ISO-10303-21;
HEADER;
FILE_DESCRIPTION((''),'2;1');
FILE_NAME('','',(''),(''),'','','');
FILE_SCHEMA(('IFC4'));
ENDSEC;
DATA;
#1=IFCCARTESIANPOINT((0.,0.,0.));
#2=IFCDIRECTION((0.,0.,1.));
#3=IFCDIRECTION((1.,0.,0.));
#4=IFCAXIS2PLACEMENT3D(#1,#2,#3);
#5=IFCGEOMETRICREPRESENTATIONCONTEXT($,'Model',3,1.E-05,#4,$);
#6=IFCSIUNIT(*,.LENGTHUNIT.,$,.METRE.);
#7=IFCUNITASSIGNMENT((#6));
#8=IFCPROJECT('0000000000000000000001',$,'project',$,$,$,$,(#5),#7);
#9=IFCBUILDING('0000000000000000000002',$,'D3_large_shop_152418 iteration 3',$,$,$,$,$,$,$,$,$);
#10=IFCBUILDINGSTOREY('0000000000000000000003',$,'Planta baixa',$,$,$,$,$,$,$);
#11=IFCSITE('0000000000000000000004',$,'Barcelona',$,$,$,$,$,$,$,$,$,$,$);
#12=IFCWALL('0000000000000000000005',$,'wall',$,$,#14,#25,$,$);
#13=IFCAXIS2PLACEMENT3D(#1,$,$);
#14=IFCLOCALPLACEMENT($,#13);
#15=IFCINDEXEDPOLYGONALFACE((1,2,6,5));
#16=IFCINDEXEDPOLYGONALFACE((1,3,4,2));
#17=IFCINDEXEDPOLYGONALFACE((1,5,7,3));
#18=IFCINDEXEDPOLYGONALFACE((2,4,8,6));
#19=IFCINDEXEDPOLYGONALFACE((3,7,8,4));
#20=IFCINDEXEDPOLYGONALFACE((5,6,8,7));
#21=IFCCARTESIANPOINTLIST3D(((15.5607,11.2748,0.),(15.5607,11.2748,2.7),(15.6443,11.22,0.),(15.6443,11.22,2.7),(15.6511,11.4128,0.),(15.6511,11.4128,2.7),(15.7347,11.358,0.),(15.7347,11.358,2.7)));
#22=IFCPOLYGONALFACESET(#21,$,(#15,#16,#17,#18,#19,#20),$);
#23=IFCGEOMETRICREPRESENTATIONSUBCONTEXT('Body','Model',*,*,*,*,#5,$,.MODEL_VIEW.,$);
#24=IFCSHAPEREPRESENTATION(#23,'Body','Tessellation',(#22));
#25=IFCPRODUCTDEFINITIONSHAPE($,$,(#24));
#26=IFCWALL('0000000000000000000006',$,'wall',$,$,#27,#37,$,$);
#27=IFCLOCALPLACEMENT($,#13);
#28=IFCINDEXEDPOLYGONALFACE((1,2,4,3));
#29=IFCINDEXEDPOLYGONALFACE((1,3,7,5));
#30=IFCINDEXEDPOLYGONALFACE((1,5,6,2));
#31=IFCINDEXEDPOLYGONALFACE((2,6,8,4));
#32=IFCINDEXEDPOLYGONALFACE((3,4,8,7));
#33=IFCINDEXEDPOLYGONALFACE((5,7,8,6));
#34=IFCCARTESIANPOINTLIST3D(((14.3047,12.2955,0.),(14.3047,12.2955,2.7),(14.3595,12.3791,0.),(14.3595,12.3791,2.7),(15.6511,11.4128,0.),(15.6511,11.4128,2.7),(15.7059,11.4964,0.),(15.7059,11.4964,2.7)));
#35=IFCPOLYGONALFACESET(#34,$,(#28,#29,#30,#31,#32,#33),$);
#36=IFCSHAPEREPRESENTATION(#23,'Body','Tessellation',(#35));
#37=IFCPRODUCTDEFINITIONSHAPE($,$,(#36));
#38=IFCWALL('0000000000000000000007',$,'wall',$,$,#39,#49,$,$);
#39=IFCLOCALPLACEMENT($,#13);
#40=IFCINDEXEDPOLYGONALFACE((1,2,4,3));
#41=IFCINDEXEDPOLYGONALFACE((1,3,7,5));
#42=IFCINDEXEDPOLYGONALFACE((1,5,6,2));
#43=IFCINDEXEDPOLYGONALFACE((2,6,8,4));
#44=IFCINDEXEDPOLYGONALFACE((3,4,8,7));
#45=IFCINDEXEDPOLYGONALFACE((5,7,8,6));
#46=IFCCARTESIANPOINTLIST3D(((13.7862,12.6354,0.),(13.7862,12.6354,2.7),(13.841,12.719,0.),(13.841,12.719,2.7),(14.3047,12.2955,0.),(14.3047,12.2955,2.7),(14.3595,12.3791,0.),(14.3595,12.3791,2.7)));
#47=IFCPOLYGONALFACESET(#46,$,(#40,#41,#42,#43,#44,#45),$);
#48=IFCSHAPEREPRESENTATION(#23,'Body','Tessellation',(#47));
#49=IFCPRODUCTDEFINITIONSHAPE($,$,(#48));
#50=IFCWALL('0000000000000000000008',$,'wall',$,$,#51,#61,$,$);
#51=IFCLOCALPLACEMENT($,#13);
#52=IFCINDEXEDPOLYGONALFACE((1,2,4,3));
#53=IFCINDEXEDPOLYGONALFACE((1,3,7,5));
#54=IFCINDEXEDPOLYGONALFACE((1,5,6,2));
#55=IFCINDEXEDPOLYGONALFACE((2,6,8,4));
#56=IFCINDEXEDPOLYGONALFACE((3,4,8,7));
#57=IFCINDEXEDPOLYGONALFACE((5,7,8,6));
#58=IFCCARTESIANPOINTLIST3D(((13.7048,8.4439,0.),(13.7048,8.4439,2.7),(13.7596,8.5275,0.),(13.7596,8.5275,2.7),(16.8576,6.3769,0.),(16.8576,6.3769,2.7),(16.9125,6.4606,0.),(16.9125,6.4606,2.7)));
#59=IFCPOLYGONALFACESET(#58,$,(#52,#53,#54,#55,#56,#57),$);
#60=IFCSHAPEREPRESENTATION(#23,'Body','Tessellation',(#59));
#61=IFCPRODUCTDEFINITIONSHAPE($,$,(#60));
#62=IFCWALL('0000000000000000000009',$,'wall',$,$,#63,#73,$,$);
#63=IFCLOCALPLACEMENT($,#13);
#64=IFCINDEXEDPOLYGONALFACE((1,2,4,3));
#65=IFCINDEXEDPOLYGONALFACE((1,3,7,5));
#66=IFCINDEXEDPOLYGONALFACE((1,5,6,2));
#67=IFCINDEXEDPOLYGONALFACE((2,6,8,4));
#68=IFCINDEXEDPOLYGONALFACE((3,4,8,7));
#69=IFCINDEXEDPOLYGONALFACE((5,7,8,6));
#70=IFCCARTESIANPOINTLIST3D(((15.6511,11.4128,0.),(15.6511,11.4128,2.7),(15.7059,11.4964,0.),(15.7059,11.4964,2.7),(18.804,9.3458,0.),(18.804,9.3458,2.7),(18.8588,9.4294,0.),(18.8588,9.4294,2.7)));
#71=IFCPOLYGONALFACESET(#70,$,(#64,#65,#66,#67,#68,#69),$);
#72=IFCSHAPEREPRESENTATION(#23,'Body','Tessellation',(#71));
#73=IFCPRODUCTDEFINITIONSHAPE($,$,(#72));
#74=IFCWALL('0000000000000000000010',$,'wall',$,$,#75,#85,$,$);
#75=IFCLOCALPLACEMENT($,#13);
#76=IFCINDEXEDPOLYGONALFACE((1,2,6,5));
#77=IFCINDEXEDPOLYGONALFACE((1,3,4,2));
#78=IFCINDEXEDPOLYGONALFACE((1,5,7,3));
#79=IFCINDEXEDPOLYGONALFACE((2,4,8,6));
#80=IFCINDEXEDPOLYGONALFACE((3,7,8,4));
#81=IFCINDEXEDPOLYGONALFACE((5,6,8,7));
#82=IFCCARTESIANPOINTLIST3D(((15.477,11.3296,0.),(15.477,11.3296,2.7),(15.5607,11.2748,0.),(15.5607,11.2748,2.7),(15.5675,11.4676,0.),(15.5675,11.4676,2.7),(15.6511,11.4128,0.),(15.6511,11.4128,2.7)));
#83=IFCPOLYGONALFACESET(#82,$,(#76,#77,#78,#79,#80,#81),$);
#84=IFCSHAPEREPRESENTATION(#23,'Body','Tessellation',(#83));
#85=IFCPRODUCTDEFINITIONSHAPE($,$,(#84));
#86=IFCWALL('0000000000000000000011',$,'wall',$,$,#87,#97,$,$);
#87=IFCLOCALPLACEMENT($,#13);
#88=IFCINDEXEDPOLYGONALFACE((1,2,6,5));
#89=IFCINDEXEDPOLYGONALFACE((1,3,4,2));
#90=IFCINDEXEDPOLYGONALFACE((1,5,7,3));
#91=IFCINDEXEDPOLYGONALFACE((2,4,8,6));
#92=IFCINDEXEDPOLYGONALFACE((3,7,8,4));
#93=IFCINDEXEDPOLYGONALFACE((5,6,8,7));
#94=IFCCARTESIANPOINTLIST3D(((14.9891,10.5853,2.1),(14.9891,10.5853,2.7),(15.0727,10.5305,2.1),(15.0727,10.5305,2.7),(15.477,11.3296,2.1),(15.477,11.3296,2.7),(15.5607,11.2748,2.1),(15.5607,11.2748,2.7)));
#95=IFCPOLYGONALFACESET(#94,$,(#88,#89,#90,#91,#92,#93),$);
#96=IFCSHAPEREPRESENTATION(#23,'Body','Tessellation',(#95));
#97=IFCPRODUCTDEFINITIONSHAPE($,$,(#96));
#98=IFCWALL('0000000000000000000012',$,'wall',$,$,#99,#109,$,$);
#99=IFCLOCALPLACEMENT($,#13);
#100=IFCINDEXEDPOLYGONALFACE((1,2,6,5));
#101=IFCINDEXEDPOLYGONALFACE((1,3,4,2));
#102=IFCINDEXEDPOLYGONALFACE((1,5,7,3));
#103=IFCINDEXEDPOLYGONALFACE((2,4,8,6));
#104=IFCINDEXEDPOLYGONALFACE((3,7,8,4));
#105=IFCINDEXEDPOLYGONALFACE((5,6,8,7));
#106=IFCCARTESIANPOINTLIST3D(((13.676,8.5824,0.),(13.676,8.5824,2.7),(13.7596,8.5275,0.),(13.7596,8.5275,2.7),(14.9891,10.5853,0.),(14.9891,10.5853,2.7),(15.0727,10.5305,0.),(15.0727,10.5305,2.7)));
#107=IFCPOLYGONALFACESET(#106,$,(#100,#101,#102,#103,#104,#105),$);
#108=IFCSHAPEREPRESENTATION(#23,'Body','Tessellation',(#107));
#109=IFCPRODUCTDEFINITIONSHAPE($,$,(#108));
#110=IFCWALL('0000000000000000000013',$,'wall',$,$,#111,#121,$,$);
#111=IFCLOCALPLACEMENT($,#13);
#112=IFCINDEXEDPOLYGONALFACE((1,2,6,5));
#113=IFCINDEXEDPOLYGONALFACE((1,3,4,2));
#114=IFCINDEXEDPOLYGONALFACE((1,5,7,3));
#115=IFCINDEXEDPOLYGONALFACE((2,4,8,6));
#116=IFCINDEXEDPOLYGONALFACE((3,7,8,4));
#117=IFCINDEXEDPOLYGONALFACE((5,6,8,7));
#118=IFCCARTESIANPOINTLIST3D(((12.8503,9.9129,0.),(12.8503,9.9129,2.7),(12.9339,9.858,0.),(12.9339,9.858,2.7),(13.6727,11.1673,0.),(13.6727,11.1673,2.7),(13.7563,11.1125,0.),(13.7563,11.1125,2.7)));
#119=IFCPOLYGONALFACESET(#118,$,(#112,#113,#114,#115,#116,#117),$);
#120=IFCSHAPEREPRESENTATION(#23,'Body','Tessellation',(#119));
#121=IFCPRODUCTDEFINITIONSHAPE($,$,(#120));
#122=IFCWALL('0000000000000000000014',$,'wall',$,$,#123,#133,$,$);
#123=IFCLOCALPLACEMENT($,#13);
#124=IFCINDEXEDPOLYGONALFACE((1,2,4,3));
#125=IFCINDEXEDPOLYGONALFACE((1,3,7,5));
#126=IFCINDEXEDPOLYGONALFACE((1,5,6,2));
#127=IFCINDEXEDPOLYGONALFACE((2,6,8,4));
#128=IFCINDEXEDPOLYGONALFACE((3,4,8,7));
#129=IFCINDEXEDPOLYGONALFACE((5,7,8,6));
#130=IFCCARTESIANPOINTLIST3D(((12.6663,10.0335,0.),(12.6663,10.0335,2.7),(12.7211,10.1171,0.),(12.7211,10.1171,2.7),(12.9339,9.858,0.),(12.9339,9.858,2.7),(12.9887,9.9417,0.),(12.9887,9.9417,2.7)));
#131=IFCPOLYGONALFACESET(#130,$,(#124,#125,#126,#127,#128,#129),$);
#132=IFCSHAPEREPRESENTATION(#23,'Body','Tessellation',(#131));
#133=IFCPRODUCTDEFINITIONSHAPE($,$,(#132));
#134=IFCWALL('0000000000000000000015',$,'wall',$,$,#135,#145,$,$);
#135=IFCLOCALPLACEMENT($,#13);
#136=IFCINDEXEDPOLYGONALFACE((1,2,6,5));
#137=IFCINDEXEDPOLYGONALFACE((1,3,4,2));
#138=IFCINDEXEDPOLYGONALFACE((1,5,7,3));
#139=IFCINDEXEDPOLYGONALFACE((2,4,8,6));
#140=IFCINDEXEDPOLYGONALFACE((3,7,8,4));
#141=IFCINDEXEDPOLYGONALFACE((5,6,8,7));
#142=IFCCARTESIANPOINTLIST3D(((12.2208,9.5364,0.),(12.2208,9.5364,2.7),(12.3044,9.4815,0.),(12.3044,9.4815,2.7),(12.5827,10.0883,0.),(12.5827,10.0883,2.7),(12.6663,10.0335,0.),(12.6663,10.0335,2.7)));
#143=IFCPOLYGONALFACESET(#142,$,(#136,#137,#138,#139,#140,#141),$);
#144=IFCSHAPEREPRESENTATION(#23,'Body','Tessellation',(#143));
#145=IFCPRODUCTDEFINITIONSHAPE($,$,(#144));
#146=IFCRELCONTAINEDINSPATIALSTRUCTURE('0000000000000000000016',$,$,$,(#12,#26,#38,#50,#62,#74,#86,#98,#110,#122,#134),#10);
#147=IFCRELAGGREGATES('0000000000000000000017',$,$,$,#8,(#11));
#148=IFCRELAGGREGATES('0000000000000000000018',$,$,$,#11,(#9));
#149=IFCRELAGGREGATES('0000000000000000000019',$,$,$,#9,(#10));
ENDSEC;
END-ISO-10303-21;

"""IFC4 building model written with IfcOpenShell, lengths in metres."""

from ifc_helpers import new_model, si_unit, frame, origin, origin_with_axes, place, context, subcontext, project, spatial, polyline, outline, extrude, element, save


model = new_model("IFC4")

# Units and contexts
model_context = context("Model", 3, precision=1e-05, world=origin_with_axes())
body_context = subcontext(model_context, "Body", "Model", "MODEL_VIEW")
ifc_project = project(units=[si_unit("LENGTHUNIT", "METRE")], contexts=[model_context])

# Site, building, storey
site = spatial("IfcSite", under=ifc_project, Name="Barcelona")
building = spatial("IfcBuilding", under=site, Name="D3_large_shop_152418 iteration 3")
storey = spatial("IfcBuildingStorey", under=building, Name="Planta baixa")

# Walls
wall_1_placement = place(None, origin_with_axes())
element("IfcWall", 1, at=wall_1_placement, inside=storey, Name="wall", context=body_context, shape_type="SweptSolid", body=[
    extrude(outline(polyline([(15.5607, 11.2748), (15.6511, 11.4128), (15.7347, 11.358), (15.6443, 11.22), (15.5607, 11.2748)])), origin(), (0.0, 0.0, 1.0), 2.7),
])
wall_2_placement = place(None, origin_with_axes())
element("IfcWall", 2, at=wall_2_placement, inside=storey, Name="wall", context=body_context, shape_type="SweptSolid", body=[
    extrude(outline(polyline([(15.6511, 11.4128), (14.3047, 12.2955), (14.3595, 12.3791), (15.7059, 11.4964), (15.6511, 11.4128)])), origin(), (0.0, 0.0, 1.0), 2.7),
])
wall_3_placement = place(None, origin_with_axes())
element("IfcWall", 3, at=wall_3_placement, inside=storey, Name="wall", context=body_context, shape_type="SweptSolid", body=[
    extrude(outline(polyline([(14.3047, 12.2955), (13.7862, 12.6354), (13.841, 12.719), (14.3595, 12.3791), (14.3047, 12.2955)])), origin(), (0.0, 0.0, 1.0), 2.7),
])
wall_4_placement = place(None, origin_with_axes())
element("IfcWall", 4, at=wall_4_placement, inside=storey, Name="wall", context=body_context, shape_type="SweptSolid", body=[
    extrude(outline(polyline([(13.7596, 8.5275), (16.9125, 6.4606), (16.8576, 6.3769), (13.7048, 8.4439), (13.7596, 8.5275)])), origin(), (0.0, 0.0, 1.0), 2.7),
])
wall_5_placement = place(None, origin_with_axes())
element("IfcWall", 5, at=wall_5_placement, inside=storey, Name="wall", context=body_context, shape_type="SweptSolid", body=[
    extrude(outline(polyline([(18.804, 9.3458), (15.6511, 11.4128), (15.7059, 11.4964), (18.8588, 9.4294), (18.804, 9.3458)])), origin(), (0.0, 0.0, 1.0), 2.7),
])
wall_6_placement = place(None, origin_with_axes())
element("IfcWall", 6, at=wall_6_placement, inside=storey, Name="wall", context=body_context, shape_type="SweptSolid", body=[
    extrude(outline(polyline([(15.6511, 11.4128), (15.5607, 11.2748), (15.477, 11.3296), (15.5675, 11.4676), (15.6511, 11.4128)])), origin(), (0.0, 0.0, 1.0), 2.7),
])
wall_7_placement = place(None, origin_with_axes())
element("IfcWall", 7, at=wall_7_placement, inside=storey, Name="wall", context=body_context, shape_type="SweptSolid", body=[
    extrude(outline(polyline([(15.5607, 11.2748), (15.0727, 10.5305), (14.9891, 10.5853), (15.477, 11.3296), (15.5607, 11.2748)])), frame((0.0, 0.0, 2.1)), (0.0, 0.0, 1.0), 0.6),
])
wall_8_placement = place(None, origin_with_axes())
element("IfcWall", 8, at=wall_8_placement, inside=storey, Name="wall", context=body_context, shape_type="SweptSolid", body=[
    extrude(outline(polyline([(15.0727, 10.5305), (13.7596, 8.5275), (13.676, 8.5824), (14.9891, 10.5853), (15.0727, 10.5305)])), origin(), (0.0, 0.0, 1.0), 2.7),
])
wall_9_placement = place(None, origin_with_axes())
element("IfcWall", 9, at=wall_9_placement, inside=storey, Name="wall", context=body_context, shape_type="SweptSolid", body=[
    extrude(outline(polyline([(13.7563, 11.1125), (12.9339, 9.858), (12.8503, 9.9129), (13.6727, 11.1673), (13.7563, 11.1125)])), origin(), (0.0, 0.0, 1.0), 2.7),
])
wall_10_placement = place(None, origin_with_axes())
element("IfcWall", 10, at=wall_10_placement, inside=storey, Name="wall", context=body_context, shape_type="SweptSolid", body=[
    extrude(outline(polyline([(12.9339, 9.858), (12.6663, 10.0335), (12.7211, 10.1171), (12.9887, 9.9417), (12.9339, 9.858)])), origin(), (0.0, 0.0, 1.0), 2.7),
])
wall_11_placement = place(None, origin_with_axes())
element("IfcWall", 11, at=wall_11_placement, inside=storey, Name="wall", context=body_context, shape_type="SweptSolid", body=[
    extrude(outline(polyline([(12.6663, 10.0335), (12.3044, 9.4815), (12.2208, 9.5364), (12.5827, 10.0883), (12.6663, 10.0335)])), origin(), (0.0, 0.0, 1.0), 2.7),
])

save(model, "model.ifc")
